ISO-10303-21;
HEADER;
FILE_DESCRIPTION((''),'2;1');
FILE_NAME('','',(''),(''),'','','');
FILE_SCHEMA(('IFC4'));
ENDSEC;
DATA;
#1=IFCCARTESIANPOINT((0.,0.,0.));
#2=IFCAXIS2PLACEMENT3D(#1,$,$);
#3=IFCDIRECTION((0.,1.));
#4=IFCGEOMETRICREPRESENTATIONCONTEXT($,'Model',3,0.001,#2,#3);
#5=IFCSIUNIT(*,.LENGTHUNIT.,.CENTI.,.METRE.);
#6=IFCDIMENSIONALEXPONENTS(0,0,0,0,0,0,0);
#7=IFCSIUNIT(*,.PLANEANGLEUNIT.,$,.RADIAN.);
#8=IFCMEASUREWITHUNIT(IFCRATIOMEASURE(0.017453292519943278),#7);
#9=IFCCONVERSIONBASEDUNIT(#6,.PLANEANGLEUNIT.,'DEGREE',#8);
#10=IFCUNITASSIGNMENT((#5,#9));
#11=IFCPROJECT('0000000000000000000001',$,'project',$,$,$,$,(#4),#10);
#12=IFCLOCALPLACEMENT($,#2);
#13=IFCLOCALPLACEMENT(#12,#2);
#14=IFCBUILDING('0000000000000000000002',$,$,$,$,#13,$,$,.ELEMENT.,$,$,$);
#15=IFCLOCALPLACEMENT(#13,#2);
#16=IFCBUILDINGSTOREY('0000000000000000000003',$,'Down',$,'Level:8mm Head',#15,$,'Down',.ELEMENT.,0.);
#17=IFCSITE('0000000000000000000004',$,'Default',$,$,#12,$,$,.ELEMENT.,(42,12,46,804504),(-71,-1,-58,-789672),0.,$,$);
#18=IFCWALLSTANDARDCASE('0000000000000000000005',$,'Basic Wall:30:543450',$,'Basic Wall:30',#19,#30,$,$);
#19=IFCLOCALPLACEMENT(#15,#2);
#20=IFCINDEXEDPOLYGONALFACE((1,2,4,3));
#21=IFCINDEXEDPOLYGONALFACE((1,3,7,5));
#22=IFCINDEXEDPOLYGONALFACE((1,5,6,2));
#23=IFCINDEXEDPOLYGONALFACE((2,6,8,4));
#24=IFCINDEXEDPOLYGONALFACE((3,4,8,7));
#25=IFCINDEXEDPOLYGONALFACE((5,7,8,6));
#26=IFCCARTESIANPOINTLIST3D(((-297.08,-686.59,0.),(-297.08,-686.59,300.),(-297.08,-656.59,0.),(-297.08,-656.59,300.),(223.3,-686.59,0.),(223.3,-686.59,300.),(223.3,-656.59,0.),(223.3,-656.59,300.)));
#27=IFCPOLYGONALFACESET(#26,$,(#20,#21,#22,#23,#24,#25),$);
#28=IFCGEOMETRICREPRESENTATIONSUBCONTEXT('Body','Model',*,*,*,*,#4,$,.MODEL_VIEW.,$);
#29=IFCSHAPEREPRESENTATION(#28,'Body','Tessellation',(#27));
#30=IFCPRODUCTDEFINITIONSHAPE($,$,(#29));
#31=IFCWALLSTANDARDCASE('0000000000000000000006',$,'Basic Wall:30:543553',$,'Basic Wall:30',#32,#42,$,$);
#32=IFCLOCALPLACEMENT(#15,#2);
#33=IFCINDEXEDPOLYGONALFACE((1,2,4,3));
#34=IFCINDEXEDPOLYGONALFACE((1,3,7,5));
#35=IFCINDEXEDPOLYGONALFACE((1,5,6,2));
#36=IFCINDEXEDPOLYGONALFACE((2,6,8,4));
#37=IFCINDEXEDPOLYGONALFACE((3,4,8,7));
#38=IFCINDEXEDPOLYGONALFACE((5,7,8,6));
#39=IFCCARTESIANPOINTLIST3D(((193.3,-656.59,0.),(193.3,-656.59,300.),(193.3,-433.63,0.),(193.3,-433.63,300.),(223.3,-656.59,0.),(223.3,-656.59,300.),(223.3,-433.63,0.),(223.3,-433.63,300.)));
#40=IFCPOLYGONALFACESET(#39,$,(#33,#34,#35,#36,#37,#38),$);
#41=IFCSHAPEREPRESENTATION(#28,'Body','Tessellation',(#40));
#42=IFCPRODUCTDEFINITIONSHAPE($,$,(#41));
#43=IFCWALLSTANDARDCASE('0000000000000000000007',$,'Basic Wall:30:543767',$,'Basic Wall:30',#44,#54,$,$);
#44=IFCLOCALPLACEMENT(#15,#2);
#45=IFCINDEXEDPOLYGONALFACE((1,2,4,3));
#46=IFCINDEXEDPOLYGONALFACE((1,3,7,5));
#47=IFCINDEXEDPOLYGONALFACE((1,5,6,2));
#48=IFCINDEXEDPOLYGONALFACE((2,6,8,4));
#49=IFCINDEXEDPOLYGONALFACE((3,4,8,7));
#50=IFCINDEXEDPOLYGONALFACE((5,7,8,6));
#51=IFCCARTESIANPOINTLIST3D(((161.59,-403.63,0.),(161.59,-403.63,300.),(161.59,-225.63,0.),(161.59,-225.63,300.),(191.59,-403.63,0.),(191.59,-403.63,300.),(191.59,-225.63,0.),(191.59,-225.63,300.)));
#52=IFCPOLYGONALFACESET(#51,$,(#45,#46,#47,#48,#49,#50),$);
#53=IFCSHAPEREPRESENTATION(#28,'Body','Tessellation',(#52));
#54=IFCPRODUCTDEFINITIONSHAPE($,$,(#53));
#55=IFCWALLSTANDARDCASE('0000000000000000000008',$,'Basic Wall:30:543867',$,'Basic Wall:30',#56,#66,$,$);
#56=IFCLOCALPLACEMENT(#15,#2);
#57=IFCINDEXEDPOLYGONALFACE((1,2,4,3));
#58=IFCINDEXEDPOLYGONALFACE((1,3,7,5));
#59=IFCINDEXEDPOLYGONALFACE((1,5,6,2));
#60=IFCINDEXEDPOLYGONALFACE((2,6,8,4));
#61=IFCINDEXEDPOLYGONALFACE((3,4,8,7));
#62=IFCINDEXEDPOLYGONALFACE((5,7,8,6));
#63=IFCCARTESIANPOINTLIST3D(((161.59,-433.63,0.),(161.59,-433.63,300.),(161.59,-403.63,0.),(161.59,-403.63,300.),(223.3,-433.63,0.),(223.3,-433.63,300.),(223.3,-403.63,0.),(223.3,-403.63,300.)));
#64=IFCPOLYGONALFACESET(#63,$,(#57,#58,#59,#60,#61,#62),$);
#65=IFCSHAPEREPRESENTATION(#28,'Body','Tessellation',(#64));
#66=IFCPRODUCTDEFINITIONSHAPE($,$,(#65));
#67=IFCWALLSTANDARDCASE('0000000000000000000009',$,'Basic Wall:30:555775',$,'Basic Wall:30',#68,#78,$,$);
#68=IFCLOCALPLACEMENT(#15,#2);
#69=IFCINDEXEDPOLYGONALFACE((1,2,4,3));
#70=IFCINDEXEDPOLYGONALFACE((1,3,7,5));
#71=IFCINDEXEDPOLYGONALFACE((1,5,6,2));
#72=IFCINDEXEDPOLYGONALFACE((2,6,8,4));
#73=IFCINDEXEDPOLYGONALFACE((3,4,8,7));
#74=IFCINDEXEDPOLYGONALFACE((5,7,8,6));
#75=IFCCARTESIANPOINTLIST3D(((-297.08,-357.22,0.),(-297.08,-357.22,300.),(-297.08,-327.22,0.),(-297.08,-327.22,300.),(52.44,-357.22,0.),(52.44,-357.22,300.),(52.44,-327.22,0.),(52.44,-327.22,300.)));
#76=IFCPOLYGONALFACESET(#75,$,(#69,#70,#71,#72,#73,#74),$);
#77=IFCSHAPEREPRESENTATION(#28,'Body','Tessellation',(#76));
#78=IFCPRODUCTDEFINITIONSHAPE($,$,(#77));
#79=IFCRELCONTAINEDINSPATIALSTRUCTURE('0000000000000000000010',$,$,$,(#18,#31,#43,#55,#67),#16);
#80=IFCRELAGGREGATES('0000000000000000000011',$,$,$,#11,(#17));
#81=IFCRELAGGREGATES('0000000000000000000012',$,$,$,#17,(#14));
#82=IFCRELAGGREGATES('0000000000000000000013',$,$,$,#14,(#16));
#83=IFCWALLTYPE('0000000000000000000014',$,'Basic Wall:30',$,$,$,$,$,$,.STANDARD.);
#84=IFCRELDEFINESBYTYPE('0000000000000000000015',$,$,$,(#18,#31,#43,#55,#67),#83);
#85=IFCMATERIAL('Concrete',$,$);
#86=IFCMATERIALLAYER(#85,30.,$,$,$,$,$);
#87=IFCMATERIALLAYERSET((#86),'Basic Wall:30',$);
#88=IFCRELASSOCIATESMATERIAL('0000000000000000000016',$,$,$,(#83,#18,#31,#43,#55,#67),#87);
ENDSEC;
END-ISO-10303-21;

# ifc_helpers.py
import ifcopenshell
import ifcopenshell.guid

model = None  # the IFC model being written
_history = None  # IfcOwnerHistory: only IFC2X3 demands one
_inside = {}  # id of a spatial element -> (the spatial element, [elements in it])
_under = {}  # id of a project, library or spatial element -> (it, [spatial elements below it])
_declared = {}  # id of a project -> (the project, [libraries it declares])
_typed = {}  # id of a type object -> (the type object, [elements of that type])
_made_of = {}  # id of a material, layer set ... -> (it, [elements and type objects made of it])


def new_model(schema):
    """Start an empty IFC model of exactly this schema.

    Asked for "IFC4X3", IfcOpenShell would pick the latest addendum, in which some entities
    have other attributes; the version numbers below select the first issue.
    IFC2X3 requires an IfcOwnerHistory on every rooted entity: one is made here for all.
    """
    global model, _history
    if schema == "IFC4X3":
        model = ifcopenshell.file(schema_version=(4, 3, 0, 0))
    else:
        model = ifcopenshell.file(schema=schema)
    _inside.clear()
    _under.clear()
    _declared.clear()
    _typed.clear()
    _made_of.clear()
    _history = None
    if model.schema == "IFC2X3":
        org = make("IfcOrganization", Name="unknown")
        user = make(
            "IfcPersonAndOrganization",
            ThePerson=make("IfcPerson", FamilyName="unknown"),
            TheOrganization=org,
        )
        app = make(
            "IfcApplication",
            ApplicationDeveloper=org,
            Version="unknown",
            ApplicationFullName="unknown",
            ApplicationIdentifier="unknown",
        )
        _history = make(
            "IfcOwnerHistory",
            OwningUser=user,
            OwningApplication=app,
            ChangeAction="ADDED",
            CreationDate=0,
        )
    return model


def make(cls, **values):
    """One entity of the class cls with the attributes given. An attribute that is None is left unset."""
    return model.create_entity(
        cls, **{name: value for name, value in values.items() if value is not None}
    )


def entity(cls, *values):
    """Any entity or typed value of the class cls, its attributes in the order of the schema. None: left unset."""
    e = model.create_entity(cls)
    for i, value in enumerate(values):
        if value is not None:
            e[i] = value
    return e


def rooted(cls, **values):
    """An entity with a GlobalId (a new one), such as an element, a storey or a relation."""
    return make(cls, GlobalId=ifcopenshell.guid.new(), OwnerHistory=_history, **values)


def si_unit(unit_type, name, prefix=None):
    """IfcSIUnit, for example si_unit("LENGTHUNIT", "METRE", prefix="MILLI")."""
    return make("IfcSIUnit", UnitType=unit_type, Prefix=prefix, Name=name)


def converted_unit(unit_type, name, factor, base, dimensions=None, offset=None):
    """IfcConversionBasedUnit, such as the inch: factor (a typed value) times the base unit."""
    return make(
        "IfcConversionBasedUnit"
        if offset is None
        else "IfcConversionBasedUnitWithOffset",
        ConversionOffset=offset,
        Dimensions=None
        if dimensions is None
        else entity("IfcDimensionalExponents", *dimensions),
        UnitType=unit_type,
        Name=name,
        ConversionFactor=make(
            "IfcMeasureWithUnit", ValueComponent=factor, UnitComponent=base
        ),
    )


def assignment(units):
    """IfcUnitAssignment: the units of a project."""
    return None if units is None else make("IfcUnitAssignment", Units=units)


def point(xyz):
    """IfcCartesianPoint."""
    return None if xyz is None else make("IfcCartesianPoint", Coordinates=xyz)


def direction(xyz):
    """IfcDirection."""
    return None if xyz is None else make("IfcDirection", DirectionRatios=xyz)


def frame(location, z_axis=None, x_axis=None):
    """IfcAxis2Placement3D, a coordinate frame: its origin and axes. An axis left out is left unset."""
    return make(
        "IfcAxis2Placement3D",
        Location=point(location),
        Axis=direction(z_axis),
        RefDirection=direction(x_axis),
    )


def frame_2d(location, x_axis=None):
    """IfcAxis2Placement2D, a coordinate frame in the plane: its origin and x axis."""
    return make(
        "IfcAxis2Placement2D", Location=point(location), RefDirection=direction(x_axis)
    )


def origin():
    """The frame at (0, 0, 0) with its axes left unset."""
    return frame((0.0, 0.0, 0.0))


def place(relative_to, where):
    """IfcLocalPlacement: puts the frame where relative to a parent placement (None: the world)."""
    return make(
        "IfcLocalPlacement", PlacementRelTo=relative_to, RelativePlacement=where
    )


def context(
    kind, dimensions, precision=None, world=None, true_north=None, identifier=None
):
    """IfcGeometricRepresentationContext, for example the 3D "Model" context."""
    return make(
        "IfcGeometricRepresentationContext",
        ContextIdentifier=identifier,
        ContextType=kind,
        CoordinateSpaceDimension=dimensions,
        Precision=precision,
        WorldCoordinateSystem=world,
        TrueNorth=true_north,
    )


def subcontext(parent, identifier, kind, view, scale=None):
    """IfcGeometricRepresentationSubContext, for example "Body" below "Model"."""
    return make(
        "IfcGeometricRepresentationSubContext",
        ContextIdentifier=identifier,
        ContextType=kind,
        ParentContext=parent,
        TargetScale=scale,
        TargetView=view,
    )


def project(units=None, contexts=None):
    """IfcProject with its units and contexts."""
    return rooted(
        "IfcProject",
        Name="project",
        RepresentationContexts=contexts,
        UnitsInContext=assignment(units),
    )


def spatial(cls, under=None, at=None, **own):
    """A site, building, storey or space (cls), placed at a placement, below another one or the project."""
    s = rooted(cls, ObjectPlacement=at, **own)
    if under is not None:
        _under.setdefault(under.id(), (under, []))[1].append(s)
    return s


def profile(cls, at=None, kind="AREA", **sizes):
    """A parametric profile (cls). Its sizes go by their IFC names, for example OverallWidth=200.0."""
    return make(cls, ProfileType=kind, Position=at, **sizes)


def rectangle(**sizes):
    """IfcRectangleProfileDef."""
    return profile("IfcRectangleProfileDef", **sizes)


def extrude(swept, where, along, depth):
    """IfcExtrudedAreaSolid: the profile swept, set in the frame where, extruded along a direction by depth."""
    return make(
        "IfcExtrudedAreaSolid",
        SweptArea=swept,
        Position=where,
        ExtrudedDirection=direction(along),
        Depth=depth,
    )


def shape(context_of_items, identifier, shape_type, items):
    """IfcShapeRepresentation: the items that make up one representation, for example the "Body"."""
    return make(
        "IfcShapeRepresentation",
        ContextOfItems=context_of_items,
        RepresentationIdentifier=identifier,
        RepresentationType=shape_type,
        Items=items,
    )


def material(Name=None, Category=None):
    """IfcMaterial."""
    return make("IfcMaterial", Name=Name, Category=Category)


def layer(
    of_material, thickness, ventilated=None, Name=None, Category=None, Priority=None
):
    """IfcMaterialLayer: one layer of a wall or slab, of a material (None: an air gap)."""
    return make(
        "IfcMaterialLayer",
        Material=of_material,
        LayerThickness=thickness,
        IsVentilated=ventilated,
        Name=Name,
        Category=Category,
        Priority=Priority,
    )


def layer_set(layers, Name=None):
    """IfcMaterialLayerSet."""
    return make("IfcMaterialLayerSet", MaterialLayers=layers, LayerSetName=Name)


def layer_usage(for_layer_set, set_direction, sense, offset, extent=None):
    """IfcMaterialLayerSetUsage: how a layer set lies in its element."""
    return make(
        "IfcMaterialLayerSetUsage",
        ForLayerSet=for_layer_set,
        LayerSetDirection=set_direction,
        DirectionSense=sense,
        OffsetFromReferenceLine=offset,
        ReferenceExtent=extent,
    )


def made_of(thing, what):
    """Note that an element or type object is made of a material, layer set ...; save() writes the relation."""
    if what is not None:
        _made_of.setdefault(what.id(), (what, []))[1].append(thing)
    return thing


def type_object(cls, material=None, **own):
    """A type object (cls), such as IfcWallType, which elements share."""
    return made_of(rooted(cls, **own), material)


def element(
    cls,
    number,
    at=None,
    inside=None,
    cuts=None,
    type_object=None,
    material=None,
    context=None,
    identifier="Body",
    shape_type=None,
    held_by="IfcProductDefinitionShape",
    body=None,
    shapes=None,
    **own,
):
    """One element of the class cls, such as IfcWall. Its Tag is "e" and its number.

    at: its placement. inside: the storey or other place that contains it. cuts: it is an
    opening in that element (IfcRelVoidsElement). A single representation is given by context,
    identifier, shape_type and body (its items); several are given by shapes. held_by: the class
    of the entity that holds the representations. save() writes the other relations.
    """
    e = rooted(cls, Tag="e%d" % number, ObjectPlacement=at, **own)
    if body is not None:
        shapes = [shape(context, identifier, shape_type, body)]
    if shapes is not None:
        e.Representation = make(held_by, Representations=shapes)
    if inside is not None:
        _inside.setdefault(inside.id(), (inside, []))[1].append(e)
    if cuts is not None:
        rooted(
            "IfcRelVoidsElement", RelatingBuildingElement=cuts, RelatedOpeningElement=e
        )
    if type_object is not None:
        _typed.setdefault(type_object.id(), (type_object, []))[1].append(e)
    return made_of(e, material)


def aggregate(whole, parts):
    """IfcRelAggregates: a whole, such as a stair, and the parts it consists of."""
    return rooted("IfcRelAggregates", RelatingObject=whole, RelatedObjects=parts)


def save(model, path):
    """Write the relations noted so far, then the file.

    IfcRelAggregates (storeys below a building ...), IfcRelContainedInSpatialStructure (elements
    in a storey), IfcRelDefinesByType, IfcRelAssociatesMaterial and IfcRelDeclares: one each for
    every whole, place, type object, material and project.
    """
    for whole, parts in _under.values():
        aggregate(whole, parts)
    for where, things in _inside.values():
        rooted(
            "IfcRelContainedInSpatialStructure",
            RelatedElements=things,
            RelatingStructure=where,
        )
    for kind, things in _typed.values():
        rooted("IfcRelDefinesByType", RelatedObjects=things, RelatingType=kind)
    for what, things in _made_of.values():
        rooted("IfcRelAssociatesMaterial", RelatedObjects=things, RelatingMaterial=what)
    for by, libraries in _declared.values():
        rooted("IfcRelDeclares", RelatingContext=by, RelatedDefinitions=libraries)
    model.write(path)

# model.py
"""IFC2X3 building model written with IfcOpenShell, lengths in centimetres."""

from ifc_helpers import new_model, entity, si_unit, converted_unit, direction, frame, frame_2d, origin, place, context, subcontext, project, spatial, rectangle, extrude, material, layer, layer_set, layer_usage, type_object, element, save


model = new_model("IFC2X3")

# Units and contexts
model_context = context("Model", 3, precision=0.001, world=origin(), true_north=direction((0.0, 1.0)))
body_context = subcontext(model_context, "Body", "Model", "MODEL_VIEW")
ifc_project = project(units=[si_unit("LENGTHUNIT", "METRE", prefix="CENTI"), converted_unit("PLANEANGLEUNIT", "DEGREE", entity("IfcRatioMeasure", 0.017453292519943278), si_unit("PLANEANGLEUNIT", "RADIAN"), dimensions=[0, 0, 0, 0, 0, 0, 0])], contexts=[model_context])

# Site, building, storey
site_placement = place(None, origin())
site = spatial("IfcSite", under=ifc_project, at=site_placement, Name="Default", CompositionType="ELEMENT", RefLatitude=(42, 12, 46, 804504), RefLongitude=(-71, -1, -58, -789672), RefElevation=0.0)
building_placement = place(site_placement, origin())
building = spatial("IfcBuilding", under=site, at=building_placement, CompositionType="ELEMENT")
storey_placement = place(building_placement, origin())
storey = spatial("IfcBuildingStorey", under=building, at=storey_placement, Name="Down", ObjectType="Level:8mm Head", LongName="Down", CompositionType="ELEMENT", Elevation=0.0)

# Shared definitions
ifc_material = material(Name="Concrete")

# Walls
ifc_layer = layer(ifc_material, 30.0)
ifc_layer_set = layer_set([ifc_layer], Name="Basic Wall:30")
wall_type = type_object("IfcWallType", Name="Basic Wall:30", PredefinedType="STANDARD", material=ifc_layer_set)
ifc_layer_usage_1 = layer_usage(ifc_layer_set, "AXIS2", "POSITIVE", -15.0)
wall_1_placement = place(storey_placement, frame((-297.08, -671.59, 0.0)))
element("IfcWallStandardCase", 1, at=wall_1_placement, inside=storey, type_object=wall_type, material=ifc_layer_usage_1, Name="Basic Wall:30:543450", ObjectType="Basic Wall:30", context=body_context, shape_type="SweptSolid", body=[
    extrude(rectangle(XDim=520.39, YDim=30.0, at=frame_2d((260.19, 0.0), x_axis=(-1.0, 0.0))), origin(), (0.0, 0.0, 1.0), 300.0),
])
ifc_layer_usage_2 = layer_usage(ifc_layer_set, "AXIS2", "POSITIVE", -15.0)
wall_2_placement = place(storey_placement, frame((208.3, -656.59, 0.0), z_axis=(0.0, 0.0, 1.0), x_axis=(0.0, 1.0, 0.0)))
element("IfcWallStandardCase", 2, at=wall_2_placement, inside=storey, type_object=wall_type, material=ifc_layer_usage_2, Name="Basic Wall:30:543553", ObjectType="Basic Wall:30", context=body_context, shape_type="SweptSolid", body=[
    extrude(rectangle(XDim=222.96, YDim=30.0, at=frame_2d((111.48, 0.0), x_axis=(-1.0, 0.0))), origin(), (0.0, 0.0, 1.0), 300.0),
])
ifc_layer_usage_3 = layer_usage(ifc_layer_set, "AXIS2", "POSITIVE", -15.0)
wall_3_placement = place(storey_placement, frame((176.59, -225.63, 0.0), z_axis=(0.0, 0.0, 1.0), x_axis=(0.0, -1.0, 0.0)))
element("IfcWallStandardCase", 3, at=wall_3_placement, inside=storey, type_object=wall_type, material=ifc_layer_usage_3, Name="Basic Wall:30:543767", ObjectType="Basic Wall:30", context=body_context, shape_type="SweptSolid", body=[
    extrude(rectangle(XDim=178.0, YDim=30.0, at=frame_2d((89.0, 0.0), x_axis=(-1.0, 0.0))), origin(), (0.0, 0.0, 1.0), 300.0),
])
ifc_layer_usage_4 = layer_usage(ifc_layer_set, "AXIS2", "POSITIVE", -15.0)
wall_4_placement = place(storey_placement, frame((161.59, -418.63, 0.0)))
element("IfcWallStandardCase", 4, at=wall_4_placement, inside=storey, type_object=wall_type, material=ifc_layer_usage_4, Name="Basic Wall:30:543867", ObjectType="Basic Wall:30", context=body_context, shape_type="SweptSolid", body=[
    extrude(rectangle(XDim=61.71, YDim=30.0, at=frame_2d((30.86, 0.0), x_axis=(-1.0, 0.0))), origin(), (0.0, 0.0, 1.0), 300.0),
])
ifc_layer_usage_5 = layer_usage(ifc_layer_set, "AXIS2", "NEGATIVE", 15.0)
wall_5_placement = place(storey_placement, frame((-297.08, -342.22, 0.0)))
element("IfcWallStandardCase", 5, at=wall_5_placement, inside=storey, type_object=wall_type, material=ifc_layer_usage_5, Name="Basic Wall:30:555775", ObjectType="Basic Wall:30", context=body_context, shape_type="SweptSolid", body=[
    extrude(rectangle(XDim=349.52, YDim=30.0, at=frame_2d((174.76, 0.0), x_axis=(-1.0, 0.0))), origin(), (0.0, 0.0, 1.0), 300.0),
])

save(model, "model.ifc")
